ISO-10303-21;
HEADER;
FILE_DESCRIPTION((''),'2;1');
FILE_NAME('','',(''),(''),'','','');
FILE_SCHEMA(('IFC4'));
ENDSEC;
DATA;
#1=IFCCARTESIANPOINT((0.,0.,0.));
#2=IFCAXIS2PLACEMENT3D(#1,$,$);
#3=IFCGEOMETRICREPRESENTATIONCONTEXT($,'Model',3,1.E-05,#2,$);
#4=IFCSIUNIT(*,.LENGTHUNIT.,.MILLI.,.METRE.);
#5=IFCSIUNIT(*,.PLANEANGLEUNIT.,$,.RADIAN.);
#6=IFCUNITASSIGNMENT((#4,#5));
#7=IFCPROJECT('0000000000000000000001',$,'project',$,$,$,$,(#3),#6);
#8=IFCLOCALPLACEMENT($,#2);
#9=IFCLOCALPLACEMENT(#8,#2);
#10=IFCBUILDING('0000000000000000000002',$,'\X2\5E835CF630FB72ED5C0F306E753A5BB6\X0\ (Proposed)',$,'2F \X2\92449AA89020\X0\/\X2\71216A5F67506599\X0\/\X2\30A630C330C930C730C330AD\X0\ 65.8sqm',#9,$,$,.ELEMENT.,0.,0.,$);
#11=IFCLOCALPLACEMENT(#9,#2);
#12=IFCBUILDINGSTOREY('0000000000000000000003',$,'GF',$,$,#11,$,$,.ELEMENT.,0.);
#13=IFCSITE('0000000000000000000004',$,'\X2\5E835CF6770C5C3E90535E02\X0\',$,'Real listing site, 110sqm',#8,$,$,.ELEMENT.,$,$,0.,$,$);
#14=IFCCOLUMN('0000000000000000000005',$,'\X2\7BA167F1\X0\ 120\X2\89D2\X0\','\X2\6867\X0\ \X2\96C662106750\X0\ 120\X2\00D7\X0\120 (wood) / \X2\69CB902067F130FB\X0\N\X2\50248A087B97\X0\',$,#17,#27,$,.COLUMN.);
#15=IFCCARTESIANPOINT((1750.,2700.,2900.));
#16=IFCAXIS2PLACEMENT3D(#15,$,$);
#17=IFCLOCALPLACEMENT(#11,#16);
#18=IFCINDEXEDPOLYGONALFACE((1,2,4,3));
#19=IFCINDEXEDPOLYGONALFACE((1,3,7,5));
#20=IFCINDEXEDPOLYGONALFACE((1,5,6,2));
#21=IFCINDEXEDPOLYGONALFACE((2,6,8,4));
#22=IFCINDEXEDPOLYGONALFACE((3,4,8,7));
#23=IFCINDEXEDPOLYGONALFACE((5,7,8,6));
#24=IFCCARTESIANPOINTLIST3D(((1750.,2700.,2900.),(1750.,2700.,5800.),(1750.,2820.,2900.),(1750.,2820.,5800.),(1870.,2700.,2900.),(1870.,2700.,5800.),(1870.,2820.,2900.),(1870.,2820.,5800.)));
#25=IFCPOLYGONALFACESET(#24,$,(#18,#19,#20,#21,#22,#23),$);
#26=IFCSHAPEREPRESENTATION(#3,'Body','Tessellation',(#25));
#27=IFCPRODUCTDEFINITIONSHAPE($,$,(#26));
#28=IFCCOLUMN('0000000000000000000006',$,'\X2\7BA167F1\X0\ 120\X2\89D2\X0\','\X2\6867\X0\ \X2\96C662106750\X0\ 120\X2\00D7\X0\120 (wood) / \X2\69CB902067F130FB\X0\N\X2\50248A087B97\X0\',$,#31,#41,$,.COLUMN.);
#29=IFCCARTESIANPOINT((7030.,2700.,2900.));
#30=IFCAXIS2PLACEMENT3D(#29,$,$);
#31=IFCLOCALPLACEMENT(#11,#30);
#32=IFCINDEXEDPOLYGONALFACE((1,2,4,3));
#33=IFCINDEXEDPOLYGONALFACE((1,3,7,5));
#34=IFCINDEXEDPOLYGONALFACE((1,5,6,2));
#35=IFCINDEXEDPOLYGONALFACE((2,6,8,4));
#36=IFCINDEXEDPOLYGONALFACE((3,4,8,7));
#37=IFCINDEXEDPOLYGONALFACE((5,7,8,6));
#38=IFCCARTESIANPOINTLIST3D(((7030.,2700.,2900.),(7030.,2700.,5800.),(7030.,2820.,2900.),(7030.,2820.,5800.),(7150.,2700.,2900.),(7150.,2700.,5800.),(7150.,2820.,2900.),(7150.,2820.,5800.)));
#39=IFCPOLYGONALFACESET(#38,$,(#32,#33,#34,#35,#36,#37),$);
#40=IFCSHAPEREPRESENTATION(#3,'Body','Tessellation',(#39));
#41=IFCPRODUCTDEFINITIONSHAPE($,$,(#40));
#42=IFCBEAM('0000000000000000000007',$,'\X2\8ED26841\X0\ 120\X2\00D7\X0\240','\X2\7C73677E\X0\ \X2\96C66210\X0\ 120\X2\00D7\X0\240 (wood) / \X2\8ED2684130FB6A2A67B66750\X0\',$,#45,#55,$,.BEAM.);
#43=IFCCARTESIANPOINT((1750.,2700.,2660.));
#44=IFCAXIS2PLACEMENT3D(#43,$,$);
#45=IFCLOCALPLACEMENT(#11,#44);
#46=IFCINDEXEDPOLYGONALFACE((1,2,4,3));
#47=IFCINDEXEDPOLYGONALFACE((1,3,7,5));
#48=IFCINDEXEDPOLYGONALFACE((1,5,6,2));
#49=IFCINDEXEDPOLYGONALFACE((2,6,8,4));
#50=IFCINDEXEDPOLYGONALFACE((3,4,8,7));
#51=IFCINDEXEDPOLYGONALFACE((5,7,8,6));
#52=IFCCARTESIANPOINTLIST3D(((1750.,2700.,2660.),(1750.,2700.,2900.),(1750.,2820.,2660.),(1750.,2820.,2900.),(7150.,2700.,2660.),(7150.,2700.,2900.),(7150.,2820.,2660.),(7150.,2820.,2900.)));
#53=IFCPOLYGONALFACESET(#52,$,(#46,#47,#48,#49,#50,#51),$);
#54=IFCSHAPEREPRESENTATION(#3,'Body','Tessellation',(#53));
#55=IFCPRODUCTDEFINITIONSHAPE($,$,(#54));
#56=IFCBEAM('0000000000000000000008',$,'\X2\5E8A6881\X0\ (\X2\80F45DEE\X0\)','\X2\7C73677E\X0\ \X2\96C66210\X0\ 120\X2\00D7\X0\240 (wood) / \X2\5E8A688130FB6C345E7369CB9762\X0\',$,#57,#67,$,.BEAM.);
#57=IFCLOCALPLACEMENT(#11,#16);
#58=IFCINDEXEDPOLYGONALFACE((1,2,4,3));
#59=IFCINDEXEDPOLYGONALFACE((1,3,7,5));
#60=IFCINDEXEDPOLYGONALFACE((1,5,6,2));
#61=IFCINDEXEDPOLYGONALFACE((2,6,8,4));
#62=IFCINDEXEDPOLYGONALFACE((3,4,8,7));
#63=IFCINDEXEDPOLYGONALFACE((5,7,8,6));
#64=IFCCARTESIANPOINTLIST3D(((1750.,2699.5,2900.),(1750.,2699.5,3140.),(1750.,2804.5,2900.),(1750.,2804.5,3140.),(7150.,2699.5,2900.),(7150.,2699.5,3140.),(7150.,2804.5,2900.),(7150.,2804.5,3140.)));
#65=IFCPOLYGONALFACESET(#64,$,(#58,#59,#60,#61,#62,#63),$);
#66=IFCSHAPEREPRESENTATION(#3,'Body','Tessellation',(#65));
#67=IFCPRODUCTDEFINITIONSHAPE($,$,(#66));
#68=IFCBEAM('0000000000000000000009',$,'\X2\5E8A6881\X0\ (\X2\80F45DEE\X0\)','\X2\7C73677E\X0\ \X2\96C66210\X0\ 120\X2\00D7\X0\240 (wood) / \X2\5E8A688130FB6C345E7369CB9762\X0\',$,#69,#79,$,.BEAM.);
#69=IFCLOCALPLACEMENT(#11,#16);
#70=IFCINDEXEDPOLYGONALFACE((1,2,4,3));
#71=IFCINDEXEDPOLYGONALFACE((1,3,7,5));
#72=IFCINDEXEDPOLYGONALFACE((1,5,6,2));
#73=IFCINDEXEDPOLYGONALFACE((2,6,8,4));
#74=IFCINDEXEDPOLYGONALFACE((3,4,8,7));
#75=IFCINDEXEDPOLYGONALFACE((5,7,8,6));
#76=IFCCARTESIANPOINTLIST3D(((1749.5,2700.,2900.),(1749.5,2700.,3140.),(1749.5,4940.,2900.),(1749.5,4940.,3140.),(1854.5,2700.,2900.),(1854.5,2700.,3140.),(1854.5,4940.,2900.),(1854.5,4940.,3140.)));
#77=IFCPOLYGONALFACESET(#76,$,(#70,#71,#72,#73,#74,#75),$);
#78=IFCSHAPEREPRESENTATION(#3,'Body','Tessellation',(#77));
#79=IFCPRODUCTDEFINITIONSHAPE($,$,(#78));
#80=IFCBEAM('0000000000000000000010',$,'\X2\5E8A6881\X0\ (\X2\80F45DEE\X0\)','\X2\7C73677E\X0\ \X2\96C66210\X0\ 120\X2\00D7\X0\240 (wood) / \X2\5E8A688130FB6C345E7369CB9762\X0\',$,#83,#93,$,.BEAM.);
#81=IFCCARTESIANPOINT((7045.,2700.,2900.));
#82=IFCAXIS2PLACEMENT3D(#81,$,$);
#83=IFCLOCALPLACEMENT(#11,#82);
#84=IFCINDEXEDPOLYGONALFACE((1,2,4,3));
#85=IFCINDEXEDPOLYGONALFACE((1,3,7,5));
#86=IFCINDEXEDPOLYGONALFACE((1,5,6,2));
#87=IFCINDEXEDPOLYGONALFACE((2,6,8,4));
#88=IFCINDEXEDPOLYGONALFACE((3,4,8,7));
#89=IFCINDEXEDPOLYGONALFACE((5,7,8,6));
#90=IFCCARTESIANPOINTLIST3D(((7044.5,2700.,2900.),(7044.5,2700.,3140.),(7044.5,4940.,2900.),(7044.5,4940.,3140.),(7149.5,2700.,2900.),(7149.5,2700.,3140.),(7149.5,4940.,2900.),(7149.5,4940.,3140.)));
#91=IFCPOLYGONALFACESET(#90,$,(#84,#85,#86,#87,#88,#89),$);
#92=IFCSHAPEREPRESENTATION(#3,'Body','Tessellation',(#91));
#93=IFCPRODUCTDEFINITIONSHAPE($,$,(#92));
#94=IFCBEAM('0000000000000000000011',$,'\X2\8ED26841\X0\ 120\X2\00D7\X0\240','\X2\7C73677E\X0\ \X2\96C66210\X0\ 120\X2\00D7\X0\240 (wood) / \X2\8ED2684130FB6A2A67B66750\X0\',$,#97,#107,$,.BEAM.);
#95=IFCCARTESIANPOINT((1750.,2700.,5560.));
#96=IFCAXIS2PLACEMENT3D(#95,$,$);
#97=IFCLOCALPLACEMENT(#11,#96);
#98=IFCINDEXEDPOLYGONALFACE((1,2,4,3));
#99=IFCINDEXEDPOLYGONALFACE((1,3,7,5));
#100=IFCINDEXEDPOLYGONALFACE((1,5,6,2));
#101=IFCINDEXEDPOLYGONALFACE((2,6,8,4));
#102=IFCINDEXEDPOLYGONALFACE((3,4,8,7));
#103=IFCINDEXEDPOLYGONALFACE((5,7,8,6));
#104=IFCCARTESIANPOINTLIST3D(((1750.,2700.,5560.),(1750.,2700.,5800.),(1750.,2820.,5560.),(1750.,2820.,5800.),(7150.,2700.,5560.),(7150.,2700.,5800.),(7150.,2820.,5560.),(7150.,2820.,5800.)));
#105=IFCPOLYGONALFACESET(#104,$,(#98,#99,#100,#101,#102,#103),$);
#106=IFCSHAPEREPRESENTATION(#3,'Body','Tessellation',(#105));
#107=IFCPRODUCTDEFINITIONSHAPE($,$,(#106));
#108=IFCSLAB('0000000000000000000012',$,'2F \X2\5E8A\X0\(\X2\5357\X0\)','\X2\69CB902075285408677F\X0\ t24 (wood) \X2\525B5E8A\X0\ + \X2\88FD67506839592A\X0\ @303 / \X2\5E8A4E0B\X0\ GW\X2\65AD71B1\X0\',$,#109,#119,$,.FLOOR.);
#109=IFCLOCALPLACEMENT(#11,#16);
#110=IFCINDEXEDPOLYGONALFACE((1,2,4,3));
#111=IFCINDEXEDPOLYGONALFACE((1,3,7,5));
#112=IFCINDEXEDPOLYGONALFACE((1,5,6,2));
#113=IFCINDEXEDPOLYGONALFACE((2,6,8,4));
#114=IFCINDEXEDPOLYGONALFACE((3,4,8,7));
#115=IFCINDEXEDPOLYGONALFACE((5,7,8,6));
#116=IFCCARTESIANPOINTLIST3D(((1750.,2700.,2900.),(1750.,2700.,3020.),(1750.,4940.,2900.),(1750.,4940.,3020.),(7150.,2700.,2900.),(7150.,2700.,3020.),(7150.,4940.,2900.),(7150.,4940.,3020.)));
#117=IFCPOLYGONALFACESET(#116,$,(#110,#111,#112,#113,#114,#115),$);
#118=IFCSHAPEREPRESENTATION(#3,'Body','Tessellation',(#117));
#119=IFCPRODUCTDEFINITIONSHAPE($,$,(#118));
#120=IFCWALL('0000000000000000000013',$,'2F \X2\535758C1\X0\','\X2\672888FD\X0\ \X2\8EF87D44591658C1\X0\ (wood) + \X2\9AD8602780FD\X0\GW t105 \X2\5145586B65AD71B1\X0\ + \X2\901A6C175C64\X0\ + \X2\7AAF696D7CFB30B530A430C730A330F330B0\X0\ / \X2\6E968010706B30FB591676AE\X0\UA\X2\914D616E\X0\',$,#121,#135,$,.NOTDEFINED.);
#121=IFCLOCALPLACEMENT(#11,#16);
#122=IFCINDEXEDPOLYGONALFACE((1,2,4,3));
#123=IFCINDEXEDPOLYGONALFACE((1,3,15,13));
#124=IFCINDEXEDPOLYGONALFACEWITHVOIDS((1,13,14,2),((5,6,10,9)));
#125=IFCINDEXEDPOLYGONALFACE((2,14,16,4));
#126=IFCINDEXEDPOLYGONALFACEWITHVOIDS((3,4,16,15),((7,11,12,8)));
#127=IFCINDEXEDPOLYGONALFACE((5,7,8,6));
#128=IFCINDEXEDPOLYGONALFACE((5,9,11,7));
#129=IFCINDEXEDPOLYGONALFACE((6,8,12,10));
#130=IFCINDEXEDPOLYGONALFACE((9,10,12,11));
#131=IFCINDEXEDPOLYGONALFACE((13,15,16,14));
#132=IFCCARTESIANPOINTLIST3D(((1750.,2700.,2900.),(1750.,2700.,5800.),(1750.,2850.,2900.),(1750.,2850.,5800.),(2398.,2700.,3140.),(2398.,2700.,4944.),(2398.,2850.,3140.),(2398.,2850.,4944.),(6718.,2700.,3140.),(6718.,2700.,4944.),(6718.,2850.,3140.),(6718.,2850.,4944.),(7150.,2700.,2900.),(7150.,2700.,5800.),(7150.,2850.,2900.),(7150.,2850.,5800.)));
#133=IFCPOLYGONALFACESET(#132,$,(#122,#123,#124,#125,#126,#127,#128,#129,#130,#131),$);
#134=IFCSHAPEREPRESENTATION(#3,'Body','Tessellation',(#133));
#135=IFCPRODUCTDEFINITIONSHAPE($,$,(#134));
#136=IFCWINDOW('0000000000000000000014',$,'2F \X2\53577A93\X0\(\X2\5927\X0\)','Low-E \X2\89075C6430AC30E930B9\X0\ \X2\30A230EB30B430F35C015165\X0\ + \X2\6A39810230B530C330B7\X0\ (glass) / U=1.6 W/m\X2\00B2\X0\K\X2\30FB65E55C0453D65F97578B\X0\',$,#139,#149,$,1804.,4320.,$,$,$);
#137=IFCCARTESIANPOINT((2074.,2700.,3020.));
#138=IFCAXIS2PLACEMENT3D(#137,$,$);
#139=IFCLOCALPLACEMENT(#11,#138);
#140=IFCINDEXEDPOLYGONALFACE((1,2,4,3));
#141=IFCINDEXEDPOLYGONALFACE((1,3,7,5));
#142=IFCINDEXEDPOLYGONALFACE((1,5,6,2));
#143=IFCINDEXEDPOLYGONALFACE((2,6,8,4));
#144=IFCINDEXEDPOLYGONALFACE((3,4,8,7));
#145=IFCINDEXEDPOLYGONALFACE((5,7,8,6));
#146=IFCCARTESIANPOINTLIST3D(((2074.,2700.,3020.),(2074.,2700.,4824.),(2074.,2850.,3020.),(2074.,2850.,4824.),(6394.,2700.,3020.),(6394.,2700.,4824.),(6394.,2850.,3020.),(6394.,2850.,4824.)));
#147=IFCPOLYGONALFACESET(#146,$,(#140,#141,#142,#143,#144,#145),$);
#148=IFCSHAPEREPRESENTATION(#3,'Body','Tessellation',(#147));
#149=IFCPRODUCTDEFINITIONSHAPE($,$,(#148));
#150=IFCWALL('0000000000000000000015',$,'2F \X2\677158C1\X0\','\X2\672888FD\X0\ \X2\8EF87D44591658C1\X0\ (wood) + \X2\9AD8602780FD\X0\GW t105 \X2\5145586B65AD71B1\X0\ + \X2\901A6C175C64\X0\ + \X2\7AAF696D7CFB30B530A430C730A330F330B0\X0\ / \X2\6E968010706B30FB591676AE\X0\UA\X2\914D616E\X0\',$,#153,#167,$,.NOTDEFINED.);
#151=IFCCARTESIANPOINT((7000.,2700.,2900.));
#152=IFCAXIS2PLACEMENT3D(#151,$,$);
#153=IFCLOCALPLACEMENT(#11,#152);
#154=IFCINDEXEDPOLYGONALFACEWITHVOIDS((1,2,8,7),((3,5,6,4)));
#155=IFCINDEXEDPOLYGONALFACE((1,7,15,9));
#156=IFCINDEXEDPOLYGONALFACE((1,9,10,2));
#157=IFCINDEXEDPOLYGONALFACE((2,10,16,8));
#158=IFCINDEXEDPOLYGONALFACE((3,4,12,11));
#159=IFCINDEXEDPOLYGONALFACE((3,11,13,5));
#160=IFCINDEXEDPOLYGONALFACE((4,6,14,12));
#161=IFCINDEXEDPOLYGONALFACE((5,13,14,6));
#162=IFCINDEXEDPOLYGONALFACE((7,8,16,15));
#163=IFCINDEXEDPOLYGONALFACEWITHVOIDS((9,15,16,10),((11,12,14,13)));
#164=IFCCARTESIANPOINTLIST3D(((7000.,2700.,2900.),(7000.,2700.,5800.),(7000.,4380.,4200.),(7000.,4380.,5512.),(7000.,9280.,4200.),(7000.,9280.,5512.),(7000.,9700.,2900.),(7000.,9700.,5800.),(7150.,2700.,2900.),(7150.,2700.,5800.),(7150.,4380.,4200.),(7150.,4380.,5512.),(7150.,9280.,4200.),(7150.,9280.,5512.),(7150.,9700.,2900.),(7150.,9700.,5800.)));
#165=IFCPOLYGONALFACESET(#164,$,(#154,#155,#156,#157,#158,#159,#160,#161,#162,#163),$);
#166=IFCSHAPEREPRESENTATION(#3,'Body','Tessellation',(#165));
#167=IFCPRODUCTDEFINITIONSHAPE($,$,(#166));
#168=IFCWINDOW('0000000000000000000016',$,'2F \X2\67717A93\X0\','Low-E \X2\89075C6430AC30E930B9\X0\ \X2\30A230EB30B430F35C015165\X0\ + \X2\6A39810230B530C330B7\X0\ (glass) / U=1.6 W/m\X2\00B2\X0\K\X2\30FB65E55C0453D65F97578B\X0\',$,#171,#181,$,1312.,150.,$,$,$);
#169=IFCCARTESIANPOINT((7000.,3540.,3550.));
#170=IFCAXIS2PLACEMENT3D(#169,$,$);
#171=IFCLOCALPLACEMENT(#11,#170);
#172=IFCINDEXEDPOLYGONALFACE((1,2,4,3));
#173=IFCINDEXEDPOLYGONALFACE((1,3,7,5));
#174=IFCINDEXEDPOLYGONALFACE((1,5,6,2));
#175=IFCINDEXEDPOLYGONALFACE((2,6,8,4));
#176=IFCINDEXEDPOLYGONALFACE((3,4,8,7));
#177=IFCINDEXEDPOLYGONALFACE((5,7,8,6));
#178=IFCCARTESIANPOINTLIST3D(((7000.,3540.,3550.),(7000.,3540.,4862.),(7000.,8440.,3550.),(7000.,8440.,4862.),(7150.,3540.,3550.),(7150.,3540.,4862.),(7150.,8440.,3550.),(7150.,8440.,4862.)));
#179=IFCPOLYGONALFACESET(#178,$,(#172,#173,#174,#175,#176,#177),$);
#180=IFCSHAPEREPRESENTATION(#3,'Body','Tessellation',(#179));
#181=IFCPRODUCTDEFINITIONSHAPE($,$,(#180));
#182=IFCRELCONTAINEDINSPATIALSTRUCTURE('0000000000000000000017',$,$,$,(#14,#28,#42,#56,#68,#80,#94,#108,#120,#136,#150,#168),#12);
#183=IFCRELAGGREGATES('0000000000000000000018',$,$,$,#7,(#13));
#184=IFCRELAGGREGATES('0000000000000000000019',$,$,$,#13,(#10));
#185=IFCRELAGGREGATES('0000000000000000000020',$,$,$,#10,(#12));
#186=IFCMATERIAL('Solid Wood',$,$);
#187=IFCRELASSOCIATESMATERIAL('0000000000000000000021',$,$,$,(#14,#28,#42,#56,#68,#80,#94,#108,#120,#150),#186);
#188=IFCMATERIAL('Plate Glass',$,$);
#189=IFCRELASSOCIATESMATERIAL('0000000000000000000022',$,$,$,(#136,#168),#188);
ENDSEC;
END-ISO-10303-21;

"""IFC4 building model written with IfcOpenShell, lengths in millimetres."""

from ifc_helpers import new_model, si_unit, frame, frame_2d, origin, place, context, project, spatial, rectangle, extrude, material, element, fill, save


model = new_model("IFC4")

# Units and contexts
model_context = context("Model", 3, precision=1e-05, world=origin())
ifc_project = project(units=[si_unit("LENGTHUNIT", "METRE", prefix="MILLI"), si_unit("PLANEANGLEUNIT", "RADIAN")], contexts=[model_context])

# Site, building, storey
site_placement = place(None, origin())
site = spatial("IfcSite", under=ifc_project, at=site_placement, Name="広島県尾道市", ObjectType="Real listing site, 110sqm", CompositionType="ELEMENT", RefElevation=0.0)
building_placement = place(site_placement, origin())
building = spatial("IfcBuilding", under=site, at=building_placement, Name="広島・狭小の町家 (Proposed)", ObjectType="2F 鉄骨造/無機材料/ウッドデッキ 65.8sqm", CompositionType="ELEMENT", ElevationOfRefHeight=0.0, ElevationOfTerrain=0.0)
storey_placement = place(building_placement, origin())
storey = spatial("IfcBuildingStorey", under=building, at=storey_placement, Name="GF", CompositionType="ELEMENT", Elevation=0.0)

# Columns
ifc_material_1 = material(Name="Solid Wood")
column_1_placement = place(storey_placement, frame((1750.0, 2700.0, 2900.0)))
element("IfcColumn", 1, at=column_1_placement, inside=storey, material=ifc_material_1, Name="管柱 120角", Description="桧 集成材 120×120 (wood) / 構造柱・N値計算", PredefinedType="COLUMN", context=model_context, shape_type="SweptSolid", body=[
    extrude(rectangle(XDim=120.0, YDim=120.0, at=frame_2d((60.0, 60.0))), frame((1750.0, 2700.0, 2900.0)), (0.0, 0.0, 1.0), 2900.0),
])
column_2_placement = place(storey_placement, frame((7030.0, 2700.0, 2900.0)))
element("IfcColumn", 2, at=column_2_placement, inside=storey, material=ifc_material_1, Name="管柱 120角", Description="桧 集成材 120×120 (wood) / 構造柱・N値計算", PredefinedType="COLUMN", context=model_context, shape_type="SweptSolid", body=[
    extrude(rectangle(XDim=120.0, YDim=120.0, at=frame_2d((60.0, 60.0))), frame((7030.0, 2700.0, 2900.0)), (0.0, 0.0, 1.0), 2900.0),
])

# Beams
beam_1_placement = place(storey_placement, frame((1750.0, 2700.0, 2660.0)))
element("IfcBeam", 3, at=beam_1_placement, inside=storey, material=ifc_material_1, Name="軒桁 120×240", Description="米松 集成 120×240 (wood) / 軒桁・横架材", PredefinedType="BEAM", context=model_context, shape_type="SweptSolid", body=[
    extrude(rectangle(XDim=5400.0, YDim=120.0, at=frame_2d((2700.0, 60.0))), frame((1750.0, 2700.0, 2660.0)), (0.0, 0.0, 1.0), 240.0),
])
beam_2_placement = place(storey_placement, frame((1750.0, 2700.0, 2900.0)))
element("IfcBeam", 4, at=beam_2_placement, inside=storey, material=ifc_material_1, Name="床梁 (胴差)", Description="米松 集成 120×240 (wood) / 床梁・水平構面", PredefinedType="BEAM", context=model_context, shape_type="SweptSolid", body=[
    extrude(rectangle(XDim=5400.0, YDim=105.0, at=frame_2d((2700.0, 52.0))), frame((1750.0, 2700.0, 2900.0)), (0.0, 0.0, 1.0), 240.0),
])
beam_3_placement = place(storey_placement, frame((1750.0, 2700.0, 2900.0)))
element("IfcBeam", 5, at=beam_3_placement, inside=storey, material=ifc_material_1, Name="床梁 (胴差)", Description="米松 集成 120×240 (wood) / 床梁・水平構面", PredefinedType="BEAM", context=model_context, shape_type="SweptSolid", body=[
    extrude(rectangle(XDim=105.0, YDim=2240.0, at=frame_2d((52.0, 1120.0))), frame((1750.0, 2700.0, 2900.0)), (0.0, 0.0, 1.0), 240.0),
])
beam_4_placement = place(storey_placement, frame((7045.0, 2700.0, 2900.0)))
element("IfcBeam", 6, at=beam_4_placement, inside=storey, material=ifc_material_1, Name="床梁 (胴差)", Description="米松 集成 120×240 (wood) / 床梁・水平構面", PredefinedType="BEAM", context=model_context, shape_type="SweptSolid", body=[
    extrude(rectangle(XDim=105.0, YDim=2240.0, at=frame_2d((52.0, 1120.0))), frame((7045.0, 2700.0, 2900.0)), (0.0, 0.0, 1.0), 240.0),
])
beam_5_placement = place(storey_placement, frame((1750.0, 2700.0, 5560.0)))
element("IfcBeam", 7, at=beam_5_placement, inside=storey, material=ifc_material_1, Name="軒桁 120×240", Description="米松 集成 120×240 (wood) / 軒桁・横架材", PredefinedType="BEAM", context=model_context, shape_type="SweptSolid", body=[
    extrude(rectangle(XDim=5400.0, YDim=120.0, at=frame_2d((2700.0, 60.0))), frame((1750.0, 2700.0, 5560.0)), (0.0, 0.0, 1.0), 240.0),
])

# Slab
slab_placement = place(storey_placement, frame((1750.0, 2700.0, 2900.0)))
element("IfcSlab", 8, at=slab_placement, inside=storey, material=ifc_material_1, Name="2F 床(南)", Description="構造用合板 t24 (wood) 剛床 + 製材根太 @303 / 床下 GW断熱", PredefinedType="FLOOR", context=model_context, shape_type="SweptSolid", body=[
    extrude(rectangle(XDim=5400.0, YDim=2240.0, at=frame_2d((2700.0, 1120.0))), frame((1750.0, 2700.0, 2900.0)), (0.0, 0.0, 1.0), 120.0),
])

# Walls, openings, windows
wall_1_placement = place(storey_placement, frame((1750.0, 2700.0, 2900.0)))
wall_1 = element("IfcWall", 9, at=wall_1_placement, inside=storey, material=ifc_material_1, Name="2F 南壁", Description="木製 軸組外壁 (wood) + 高性能GW t105 充填断熱 + 通気層 + 窯業系サイディング / 準耐火・外皮UA配慮", PredefinedType="NOTDEFINED", context=model_context, shape_type="SweptSolid", body=[
    extrude(rectangle(XDim=5400.0, YDim=150.0, at=frame_2d((2700.0, 75.0))), frame((1750.0, 2700.0, 2900.0)), (0.0, 0.0, 1.0), 2900.0),
])
opening_1_placement = place(storey_placement, frame((2074.0, 2700.0, 3020.0)))
opening_1 = element("IfcOpeningElement", 10, at=opening_1_placement, cuts=wall_1, PredefinedType="NOTDEFINED", context=model_context, shape_type="SweptSolid", body=[
    extrude(rectangle(XDim=4320.0, YDim=150.0, at=frame_2d((2160.0, 75.0))), frame((2074.0, 2700.0, 3020.0)), (0.0, 0.0, 1.0), 1804.0),
])
ifc_material_2 = material(Name="Plate Glass")
window_1_placement = place(storey_placement, frame((2074.0, 2700.0, 3020.0)))
window_1 = element("IfcWindow", 11, at=window_1_placement, inside=storey, material=ifc_material_2, Name="2F 南窓(大)", Description="Low-E 複層ガラス アルゴン封入 + 樹脂サッシ (glass) / U=1.6 W/m²K・日射取得型", OverallHeight=1804.0, OverallWidth=4320.0, context=model_context, shape_type="SweptSolid", body=[
    extrude(rectangle(XDim=4320.0, YDim=150.0, at=frame_2d((2160.0, 75.0))), frame((2074.0, 2700.0, 3020.0)), (0.0, 0.0, 1.0), 1804.0),
])
fill(opening_1, window_1)
wall_2_placement = place(storey_placement, frame((7000.0, 2700.0, 2900.0)))
wall_2 = element("IfcWall", 12, at=wall_2_placement, inside=storey, material=ifc_material_1, Name="2F 東壁", Description="木製 軸組外壁 (wood) + 高性能GW t105 充填断熱 + 通気層 + 窯業系サイディング / 準耐火・外皮UA配慮", PredefinedType="NOTDEFINED", context=model_context, shape_type="SweptSolid", body=[
    extrude(rectangle(XDim=150.0, YDim=7000.0, at=frame_2d((75.0, 3500.0))), frame((7000.0, 2700.0, 2900.0)), (0.0, 0.0, 1.0), 2900.0),
])
opening_2_placement = place(storey_placement, frame((7000.0, 3540.0, 3550.0)))
opening_2 = element("IfcOpeningElement", 13, at=opening_2_placement, cuts=wall_2, PredefinedType="NOTDEFINED", context=model_context, shape_type="SweptSolid", body=[
    extrude(rectangle(XDim=150.0, YDim=4900.0, at=frame_2d((75.0, 2450.0))), frame((7000.0, 3540.0, 3550.0)), (0.0, 0.0, 1.0), 1312.0),
])
window_2_placement = place(storey_placement, frame((7000.0, 3540.0, 3550.0)))
window_2 = element("IfcWindow", 14, at=window_2_placement, inside=storey, material=ifc_material_2, Name="2F 東窓", Description="Low-E 複層ガラス アルゴン封入 + 樹脂サッシ (glass) / U=1.6 W/m²K・日射取得型", OverallHeight=1312.0, OverallWidth=150.0, context=model_context, shape_type="SweptSolid", body=[
    extrude(rectangle(XDim=150.0, YDim=4900.0, at=frame_2d((75.0, 2450.0))), frame((7000.0, 3540.0, 3550.0)), (0.0, 0.0, 1.0), 1312.0),
])
fill(opening_2, window_2)

save(model, "model.ifc")
